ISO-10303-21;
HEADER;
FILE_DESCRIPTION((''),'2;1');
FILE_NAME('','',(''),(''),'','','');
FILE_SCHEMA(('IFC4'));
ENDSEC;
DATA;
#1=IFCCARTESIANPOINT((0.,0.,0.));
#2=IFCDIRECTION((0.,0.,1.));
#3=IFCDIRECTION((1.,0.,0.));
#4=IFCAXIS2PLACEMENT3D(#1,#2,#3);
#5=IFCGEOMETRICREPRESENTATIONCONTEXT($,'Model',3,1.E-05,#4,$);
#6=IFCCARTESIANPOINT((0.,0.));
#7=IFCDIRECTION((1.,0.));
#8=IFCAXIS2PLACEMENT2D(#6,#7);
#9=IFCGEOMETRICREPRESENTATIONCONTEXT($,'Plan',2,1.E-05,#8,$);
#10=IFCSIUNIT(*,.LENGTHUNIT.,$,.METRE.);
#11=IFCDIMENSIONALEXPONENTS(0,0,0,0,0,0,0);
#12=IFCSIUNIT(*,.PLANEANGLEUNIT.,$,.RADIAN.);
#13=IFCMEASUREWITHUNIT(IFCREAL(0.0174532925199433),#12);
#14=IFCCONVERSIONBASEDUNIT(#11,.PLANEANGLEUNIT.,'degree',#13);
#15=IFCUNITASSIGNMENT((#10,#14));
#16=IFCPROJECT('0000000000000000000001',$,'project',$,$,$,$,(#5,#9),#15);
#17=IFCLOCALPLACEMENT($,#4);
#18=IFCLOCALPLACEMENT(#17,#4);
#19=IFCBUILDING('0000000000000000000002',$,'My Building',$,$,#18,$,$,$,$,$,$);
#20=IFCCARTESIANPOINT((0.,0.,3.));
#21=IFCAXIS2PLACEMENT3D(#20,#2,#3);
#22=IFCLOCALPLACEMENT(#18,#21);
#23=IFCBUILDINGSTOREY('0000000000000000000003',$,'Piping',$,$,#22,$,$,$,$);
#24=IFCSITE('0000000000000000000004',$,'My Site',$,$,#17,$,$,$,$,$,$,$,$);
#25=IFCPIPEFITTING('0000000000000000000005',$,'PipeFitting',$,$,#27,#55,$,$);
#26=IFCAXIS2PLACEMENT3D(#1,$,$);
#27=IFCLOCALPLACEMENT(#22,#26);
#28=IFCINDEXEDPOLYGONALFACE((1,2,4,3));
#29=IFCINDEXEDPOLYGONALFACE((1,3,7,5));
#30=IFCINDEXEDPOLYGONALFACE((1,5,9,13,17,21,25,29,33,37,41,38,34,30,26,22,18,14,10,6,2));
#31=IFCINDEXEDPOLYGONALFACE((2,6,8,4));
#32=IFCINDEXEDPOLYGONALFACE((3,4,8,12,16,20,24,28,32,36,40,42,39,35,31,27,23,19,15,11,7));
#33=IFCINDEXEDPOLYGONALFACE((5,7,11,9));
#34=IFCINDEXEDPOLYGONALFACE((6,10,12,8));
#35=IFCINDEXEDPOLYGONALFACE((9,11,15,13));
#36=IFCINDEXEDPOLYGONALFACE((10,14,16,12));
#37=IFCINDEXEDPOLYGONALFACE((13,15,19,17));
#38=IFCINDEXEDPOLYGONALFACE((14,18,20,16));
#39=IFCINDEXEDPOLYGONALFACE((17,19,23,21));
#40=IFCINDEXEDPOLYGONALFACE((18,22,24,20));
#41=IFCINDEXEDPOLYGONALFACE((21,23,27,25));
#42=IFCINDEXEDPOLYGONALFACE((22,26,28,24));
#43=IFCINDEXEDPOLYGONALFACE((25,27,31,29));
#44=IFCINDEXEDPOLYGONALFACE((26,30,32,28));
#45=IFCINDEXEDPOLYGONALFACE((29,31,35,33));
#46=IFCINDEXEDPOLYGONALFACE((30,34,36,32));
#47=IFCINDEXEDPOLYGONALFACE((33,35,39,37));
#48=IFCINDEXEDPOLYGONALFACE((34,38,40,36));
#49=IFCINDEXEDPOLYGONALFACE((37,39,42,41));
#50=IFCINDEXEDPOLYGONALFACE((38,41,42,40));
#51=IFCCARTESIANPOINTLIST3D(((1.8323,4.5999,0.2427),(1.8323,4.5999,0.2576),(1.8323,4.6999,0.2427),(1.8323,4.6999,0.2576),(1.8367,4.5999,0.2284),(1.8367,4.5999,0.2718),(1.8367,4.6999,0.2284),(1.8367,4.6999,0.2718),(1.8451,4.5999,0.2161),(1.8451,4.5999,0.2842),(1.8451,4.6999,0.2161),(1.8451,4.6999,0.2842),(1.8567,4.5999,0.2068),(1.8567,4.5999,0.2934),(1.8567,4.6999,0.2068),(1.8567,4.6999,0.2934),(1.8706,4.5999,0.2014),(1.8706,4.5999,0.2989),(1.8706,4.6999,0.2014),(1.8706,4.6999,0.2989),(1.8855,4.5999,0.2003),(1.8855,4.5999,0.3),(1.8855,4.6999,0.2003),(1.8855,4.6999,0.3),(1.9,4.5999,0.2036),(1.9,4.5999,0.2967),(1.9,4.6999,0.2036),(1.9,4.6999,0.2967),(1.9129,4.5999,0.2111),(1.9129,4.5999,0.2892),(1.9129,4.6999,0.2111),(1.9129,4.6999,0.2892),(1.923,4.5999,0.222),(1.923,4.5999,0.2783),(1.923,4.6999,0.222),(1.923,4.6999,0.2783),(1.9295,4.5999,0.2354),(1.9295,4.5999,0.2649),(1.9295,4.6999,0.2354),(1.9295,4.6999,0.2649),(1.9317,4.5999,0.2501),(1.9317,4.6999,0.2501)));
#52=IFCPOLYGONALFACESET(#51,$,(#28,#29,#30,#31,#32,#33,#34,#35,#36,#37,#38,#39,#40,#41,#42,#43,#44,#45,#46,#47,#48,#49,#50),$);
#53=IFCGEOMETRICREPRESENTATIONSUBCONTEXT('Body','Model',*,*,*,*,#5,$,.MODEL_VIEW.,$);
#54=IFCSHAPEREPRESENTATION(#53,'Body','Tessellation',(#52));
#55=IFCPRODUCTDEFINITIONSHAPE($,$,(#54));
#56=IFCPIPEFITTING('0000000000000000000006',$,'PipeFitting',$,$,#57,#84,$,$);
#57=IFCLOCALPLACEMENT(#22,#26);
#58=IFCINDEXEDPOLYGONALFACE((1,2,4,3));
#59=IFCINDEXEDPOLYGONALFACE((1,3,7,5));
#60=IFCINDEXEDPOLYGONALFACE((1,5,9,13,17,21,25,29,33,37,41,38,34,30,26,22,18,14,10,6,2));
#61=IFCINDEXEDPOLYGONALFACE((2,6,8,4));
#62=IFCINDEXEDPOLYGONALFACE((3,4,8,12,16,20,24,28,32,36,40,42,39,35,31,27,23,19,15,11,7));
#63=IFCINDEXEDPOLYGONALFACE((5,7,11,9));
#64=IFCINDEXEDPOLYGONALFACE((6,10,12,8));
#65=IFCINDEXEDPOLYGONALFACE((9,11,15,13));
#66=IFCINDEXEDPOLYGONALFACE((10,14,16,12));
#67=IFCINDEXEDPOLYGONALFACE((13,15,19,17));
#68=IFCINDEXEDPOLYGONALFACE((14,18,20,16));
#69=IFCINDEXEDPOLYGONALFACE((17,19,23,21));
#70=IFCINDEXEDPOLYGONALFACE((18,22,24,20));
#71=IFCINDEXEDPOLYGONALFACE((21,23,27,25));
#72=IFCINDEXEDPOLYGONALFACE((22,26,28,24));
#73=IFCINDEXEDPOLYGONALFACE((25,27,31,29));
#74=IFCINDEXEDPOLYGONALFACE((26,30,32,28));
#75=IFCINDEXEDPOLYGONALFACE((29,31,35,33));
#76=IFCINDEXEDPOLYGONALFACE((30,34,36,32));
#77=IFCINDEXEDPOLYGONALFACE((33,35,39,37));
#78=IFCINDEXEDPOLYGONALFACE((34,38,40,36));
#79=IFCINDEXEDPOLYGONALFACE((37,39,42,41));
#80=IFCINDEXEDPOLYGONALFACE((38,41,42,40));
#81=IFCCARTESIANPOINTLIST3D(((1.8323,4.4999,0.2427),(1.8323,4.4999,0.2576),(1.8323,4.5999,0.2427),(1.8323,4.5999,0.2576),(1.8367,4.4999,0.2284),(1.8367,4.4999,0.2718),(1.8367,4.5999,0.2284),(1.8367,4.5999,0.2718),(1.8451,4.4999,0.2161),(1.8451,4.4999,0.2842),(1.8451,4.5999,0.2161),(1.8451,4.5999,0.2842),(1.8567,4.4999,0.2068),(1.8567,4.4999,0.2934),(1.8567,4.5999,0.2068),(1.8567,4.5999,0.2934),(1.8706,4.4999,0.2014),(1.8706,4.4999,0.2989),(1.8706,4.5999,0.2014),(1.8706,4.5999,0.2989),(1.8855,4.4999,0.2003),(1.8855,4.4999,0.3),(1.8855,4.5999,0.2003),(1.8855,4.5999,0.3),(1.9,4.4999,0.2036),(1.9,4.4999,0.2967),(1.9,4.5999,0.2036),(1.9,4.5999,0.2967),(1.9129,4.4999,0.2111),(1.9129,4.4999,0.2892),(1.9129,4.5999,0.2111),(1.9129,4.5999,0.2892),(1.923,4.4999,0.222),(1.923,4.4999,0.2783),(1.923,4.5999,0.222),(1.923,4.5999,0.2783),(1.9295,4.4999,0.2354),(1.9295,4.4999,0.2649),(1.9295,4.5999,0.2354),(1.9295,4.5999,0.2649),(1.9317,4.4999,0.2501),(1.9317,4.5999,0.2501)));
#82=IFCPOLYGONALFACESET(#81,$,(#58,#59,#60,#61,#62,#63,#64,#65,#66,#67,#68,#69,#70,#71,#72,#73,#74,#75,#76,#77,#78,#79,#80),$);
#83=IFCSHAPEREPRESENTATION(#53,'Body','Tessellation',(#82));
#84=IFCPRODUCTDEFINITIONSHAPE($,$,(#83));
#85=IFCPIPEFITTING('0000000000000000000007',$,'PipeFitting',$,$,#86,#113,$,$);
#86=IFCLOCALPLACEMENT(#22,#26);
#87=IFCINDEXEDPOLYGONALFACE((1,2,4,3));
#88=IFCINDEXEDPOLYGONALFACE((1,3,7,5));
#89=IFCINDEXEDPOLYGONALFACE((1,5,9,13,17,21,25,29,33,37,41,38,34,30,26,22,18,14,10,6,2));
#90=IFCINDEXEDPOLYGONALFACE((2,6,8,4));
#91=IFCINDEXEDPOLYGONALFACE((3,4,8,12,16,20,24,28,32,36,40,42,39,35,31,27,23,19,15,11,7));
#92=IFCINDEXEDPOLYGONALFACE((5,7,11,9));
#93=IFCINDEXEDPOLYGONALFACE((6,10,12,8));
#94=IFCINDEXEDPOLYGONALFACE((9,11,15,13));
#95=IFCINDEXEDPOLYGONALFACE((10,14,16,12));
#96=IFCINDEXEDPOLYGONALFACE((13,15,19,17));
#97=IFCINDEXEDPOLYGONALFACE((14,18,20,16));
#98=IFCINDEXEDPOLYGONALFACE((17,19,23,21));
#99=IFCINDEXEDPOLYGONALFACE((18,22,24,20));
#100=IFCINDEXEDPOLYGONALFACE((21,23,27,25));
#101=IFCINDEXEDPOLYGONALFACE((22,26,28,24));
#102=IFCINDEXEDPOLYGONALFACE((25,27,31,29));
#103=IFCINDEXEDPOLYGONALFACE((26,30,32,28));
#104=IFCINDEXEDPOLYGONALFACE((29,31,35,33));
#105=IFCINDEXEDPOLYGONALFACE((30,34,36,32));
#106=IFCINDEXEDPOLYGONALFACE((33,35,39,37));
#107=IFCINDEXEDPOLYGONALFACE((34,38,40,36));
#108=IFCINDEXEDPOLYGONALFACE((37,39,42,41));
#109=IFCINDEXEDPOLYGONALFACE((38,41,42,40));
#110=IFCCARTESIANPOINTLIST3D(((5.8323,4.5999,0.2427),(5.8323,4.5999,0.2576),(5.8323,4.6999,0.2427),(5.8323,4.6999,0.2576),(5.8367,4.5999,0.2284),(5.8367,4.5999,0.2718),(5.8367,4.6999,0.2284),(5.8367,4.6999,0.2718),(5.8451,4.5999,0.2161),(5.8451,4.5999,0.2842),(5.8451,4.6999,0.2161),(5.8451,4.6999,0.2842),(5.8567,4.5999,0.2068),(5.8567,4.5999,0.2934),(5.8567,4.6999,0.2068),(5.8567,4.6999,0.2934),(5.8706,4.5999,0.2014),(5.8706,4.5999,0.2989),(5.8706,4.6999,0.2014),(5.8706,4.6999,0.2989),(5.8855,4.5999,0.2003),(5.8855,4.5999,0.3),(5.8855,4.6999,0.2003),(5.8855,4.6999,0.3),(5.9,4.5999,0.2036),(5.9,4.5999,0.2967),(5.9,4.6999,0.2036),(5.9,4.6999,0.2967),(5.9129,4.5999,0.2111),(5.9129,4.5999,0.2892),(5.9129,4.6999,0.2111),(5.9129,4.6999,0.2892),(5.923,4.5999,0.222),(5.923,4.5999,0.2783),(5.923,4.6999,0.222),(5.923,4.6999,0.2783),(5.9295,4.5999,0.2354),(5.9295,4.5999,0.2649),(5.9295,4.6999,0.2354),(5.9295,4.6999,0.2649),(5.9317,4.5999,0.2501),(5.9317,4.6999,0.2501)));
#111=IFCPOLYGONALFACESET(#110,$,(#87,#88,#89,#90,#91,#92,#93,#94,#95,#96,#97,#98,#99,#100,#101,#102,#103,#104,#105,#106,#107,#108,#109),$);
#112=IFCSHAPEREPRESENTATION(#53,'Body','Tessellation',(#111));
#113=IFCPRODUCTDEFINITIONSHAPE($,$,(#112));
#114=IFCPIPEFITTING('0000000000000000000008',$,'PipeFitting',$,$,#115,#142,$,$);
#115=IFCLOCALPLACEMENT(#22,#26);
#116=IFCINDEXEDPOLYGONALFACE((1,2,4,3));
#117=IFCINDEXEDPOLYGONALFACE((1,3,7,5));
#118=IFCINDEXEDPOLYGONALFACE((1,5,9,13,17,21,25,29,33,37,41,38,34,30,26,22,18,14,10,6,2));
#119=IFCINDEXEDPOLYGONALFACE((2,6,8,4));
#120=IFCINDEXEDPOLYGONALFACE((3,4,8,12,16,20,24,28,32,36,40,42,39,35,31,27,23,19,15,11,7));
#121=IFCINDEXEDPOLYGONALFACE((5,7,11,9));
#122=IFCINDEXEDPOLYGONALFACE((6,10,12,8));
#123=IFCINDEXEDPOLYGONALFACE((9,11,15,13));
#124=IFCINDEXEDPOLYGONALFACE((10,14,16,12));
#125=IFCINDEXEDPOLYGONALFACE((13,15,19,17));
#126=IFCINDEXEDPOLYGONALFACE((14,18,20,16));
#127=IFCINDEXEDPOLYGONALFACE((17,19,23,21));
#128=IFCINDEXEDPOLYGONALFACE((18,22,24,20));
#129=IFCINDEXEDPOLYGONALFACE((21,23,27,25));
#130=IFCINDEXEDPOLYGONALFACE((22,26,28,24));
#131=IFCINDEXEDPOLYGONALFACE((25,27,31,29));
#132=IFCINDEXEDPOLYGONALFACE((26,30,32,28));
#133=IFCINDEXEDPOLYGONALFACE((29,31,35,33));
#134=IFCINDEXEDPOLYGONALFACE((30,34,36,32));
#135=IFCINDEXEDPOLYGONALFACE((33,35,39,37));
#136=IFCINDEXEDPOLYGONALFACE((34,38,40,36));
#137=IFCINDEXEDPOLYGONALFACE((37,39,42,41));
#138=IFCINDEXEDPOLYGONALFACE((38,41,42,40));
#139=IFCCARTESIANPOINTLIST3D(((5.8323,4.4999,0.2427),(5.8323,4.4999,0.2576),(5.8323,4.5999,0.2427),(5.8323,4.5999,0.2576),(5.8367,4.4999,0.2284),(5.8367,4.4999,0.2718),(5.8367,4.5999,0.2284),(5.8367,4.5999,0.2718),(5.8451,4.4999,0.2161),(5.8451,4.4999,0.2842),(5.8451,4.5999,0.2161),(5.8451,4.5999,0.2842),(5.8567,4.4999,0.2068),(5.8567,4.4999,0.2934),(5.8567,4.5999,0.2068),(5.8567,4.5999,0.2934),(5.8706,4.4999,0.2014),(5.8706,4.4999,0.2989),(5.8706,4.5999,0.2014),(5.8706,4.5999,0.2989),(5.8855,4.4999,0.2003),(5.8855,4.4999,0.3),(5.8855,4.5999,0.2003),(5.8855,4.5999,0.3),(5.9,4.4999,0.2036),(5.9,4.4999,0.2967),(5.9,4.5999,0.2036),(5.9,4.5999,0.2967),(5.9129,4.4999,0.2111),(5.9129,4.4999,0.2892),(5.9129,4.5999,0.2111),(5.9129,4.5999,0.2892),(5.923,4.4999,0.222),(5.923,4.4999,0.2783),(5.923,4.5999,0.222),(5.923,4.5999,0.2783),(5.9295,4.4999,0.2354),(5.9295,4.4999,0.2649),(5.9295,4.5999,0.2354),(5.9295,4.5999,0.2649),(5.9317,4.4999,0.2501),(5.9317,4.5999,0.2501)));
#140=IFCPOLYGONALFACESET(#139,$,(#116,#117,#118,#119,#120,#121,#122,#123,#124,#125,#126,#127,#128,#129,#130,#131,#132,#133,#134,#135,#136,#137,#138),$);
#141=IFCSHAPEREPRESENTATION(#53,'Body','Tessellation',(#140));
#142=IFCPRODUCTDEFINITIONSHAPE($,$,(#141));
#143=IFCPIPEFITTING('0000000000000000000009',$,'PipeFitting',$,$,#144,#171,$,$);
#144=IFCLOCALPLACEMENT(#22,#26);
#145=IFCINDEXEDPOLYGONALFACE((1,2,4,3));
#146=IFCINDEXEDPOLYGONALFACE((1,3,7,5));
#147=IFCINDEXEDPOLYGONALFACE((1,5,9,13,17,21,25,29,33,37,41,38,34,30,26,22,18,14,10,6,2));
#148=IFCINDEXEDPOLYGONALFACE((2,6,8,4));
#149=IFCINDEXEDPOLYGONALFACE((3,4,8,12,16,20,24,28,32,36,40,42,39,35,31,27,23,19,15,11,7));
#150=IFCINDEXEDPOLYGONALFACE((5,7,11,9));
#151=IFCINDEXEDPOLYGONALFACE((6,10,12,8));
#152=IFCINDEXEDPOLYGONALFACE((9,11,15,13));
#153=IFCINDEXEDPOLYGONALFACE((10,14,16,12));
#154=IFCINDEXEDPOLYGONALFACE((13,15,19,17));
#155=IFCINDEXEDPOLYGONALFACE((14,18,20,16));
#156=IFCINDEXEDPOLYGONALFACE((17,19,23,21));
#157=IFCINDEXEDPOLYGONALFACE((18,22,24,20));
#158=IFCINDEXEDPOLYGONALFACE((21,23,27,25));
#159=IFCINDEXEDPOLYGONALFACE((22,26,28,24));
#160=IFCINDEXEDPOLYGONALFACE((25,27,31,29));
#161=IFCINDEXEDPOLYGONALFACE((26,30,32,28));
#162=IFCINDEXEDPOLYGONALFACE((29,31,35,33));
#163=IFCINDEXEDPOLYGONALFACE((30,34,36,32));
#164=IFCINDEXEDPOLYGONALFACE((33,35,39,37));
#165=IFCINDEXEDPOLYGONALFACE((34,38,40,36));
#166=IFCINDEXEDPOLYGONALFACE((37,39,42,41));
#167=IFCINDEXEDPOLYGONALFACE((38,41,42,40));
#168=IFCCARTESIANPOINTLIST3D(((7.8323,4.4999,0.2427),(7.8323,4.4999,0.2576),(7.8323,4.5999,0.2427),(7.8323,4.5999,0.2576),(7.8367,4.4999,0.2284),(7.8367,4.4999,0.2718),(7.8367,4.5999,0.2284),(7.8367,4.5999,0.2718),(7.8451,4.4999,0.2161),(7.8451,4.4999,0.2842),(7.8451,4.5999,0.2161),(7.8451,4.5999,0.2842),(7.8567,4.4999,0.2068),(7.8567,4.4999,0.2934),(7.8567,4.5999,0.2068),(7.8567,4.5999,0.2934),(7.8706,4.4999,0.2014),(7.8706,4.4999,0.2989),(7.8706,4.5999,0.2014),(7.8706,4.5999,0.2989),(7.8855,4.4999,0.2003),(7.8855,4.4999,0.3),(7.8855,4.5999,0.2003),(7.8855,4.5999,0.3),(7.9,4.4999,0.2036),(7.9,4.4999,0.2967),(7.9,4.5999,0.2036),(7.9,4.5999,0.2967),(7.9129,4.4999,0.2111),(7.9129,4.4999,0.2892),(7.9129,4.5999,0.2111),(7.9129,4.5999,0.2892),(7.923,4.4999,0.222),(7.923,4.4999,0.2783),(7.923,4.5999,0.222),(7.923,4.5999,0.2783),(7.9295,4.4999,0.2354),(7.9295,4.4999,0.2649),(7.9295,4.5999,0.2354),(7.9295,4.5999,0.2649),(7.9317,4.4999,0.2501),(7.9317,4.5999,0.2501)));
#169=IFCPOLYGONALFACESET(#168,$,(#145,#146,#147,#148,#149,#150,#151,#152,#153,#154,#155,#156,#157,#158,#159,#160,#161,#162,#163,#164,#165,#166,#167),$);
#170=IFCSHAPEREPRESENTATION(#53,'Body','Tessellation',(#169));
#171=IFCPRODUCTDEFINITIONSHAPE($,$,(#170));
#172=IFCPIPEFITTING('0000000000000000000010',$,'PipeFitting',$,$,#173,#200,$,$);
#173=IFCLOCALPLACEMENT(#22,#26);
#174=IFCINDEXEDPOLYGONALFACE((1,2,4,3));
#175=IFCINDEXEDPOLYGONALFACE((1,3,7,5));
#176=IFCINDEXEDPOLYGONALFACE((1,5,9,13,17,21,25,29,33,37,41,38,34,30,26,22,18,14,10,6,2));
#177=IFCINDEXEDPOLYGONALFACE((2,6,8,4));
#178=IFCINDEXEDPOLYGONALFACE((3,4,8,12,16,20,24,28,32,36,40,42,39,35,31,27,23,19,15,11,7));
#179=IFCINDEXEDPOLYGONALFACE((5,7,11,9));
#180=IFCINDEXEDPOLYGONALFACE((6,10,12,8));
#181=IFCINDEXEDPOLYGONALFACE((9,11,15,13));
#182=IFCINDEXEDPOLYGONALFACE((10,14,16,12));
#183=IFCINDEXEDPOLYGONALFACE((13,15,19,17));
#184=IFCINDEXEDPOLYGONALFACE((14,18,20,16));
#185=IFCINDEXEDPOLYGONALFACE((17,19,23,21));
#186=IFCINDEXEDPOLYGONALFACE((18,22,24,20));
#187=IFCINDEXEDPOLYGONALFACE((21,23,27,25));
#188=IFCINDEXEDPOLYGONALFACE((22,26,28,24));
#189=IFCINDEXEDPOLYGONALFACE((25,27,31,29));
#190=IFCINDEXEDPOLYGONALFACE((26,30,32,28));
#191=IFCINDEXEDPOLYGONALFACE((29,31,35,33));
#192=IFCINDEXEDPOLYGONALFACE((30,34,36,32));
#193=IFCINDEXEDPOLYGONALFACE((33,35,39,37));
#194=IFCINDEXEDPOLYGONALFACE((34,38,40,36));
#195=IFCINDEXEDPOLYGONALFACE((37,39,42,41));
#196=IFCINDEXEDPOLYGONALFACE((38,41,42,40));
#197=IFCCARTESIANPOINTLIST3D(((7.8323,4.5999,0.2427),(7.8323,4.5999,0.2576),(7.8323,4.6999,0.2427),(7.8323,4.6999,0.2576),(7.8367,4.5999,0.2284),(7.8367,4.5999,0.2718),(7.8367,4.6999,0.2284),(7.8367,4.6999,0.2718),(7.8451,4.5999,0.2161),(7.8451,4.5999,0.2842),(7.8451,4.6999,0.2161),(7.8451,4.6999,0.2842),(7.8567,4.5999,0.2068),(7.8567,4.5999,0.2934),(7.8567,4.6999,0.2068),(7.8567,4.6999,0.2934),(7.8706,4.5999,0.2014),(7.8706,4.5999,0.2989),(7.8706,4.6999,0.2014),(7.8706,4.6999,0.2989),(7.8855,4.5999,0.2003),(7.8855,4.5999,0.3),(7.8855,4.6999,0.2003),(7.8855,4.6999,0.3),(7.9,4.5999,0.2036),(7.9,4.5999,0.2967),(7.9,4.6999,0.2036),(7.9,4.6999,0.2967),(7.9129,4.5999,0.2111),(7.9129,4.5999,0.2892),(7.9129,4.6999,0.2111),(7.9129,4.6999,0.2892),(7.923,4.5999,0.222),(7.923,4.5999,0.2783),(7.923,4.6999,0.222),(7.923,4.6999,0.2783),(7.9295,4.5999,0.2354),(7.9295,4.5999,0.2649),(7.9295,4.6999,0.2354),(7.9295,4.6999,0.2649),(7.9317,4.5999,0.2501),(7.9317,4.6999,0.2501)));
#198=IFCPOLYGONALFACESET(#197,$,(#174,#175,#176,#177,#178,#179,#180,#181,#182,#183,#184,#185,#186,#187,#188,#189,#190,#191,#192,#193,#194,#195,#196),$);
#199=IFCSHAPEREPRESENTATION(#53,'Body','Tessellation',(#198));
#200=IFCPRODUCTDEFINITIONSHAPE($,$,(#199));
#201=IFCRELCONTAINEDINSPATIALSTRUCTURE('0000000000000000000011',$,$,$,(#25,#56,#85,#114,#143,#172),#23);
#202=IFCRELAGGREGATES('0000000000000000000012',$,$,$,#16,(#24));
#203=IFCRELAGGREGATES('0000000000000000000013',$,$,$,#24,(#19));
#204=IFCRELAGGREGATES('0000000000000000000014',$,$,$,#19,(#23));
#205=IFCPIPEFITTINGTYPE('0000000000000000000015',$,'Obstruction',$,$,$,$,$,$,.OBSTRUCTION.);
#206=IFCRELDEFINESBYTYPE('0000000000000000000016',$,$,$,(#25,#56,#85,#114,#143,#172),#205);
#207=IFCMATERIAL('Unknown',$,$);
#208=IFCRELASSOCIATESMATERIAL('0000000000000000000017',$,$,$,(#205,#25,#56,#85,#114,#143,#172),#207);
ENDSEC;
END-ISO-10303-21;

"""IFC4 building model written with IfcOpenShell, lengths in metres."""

from ifc_helpers import new_model, entity, si_unit, converted_unit, frame, origin_with_axes, origin_2d_with_axis, place, context, subcontext, project, spatial, circle, extrude, material, material_profile, profile_set, profile_usage, type_object, element, save


model = new_model("IFC4")

# Units and contexts
model_context = context("Model", 3, precision=1e-05, world=origin_with_axes())
plan_context = context("Plan", 2, precision=1e-05, world=origin_2d_with_axis())
body_context = subcontext(model_context, "Body", "Model", "MODEL_VIEW")
ifc_project = project(units=[si_unit("LENGTHUNIT", "METRE"), converted_unit("PLANEANGLEUNIT", "degree", entity("IfcReal", 0.0174532925199433), si_unit("PLANEANGLEUNIT", "RADIAN"), dimensions=[0, 0, 0, 0, 0, 0, 0])], contexts=[model_context, plan_context])

# Site, building, storey
site_placement = place(None, origin_with_axes())
site = spatial("IfcSite", under=ifc_project, at=site_placement, Name="My Site")
building_placement = place(site_placement, origin_with_axes())
building = spatial("IfcBuilding", under=site, at=building_placement, Name="My Building")
storey_placement = place(building_placement, frame((0.0, 0.0, 3.0), z_axis=(0.0, 0.0, 1.0), x_axis=(1.0, 0.0, 0.0)))
storey = spatial("IfcBuildingStorey", under=building, at=storey_placement, Name="Piping")

# Shared definitions
ifc_material = material(Name="Unknown")

# Pipe fittings
ifc_material_profile_1 = material_profile(ifc_material, circle(Radius=0.05))
ifc_profile_set_1 = profile_set([ifc_material_profile_1])
ifc_profile_usage_1 = profile_usage(ifc_profile_set_1, cardinal=5)
pipe_fitting_type_1 = type_object("IfcPipeFittingType", Name="Obstruction", PredefinedType="OBSTRUCTION", material=ifc_profile_set_1)
pipe_fitting_1_placement = place(storey_placement, frame((1.8817, 4.5999, 0.2501), z_axis=(0.0, 1.0, -0.000008), x_axis=(1.0, 0.0, 0.0)))
element("IfcPipeFitting", 1, at=pipe_fitting_1_placement, inside=storey, type_object=pipe_fitting_type_1, material=ifc_profile_usage_1, Name="PipeFitting", context=body_context, shape_type="SweptSolid", body=[
    extrude(circle(Radius=0.05), origin_with_axes(), (0.0, 0.0, 1.0), 0.1),
])
ifc_profile_usage_2 = profile_usage(ifc_profile_set_1, cardinal=5)
pipe_fitting_2_placement = place(storey_placement, frame((1.8817, 4.5999, 0.2501), z_axis=(0.0, -1.0, 0.000008), x_axis=(1.0, 0.0, 0.0)))
element("IfcPipeFitting", 2, at=pipe_fitting_2_placement, inside=storey, type_object=pipe_fitting_type_1, material=ifc_profile_usage_2, Name="PipeFitting", context=body_context, shape_type="SweptSolid", body=[
    extrude(circle(Radius=0.05), origin_with_axes(), (0.0, 0.0, 1.0), 0.1),
])
ifc_profile_usage_3 = profile_usage(ifc_profile_set_1, cardinal=5)
pipe_fitting_3_placement = place(storey_placement, frame((5.8817, 4.5999, 0.2501), z_axis=(0.0, 1.0, -0.000008), x_axis=(1.0, 0.0, 0.0)))
element("IfcPipeFitting", 3, at=pipe_fitting_3_placement, inside=storey, type_object=pipe_fitting_type_1, material=ifc_profile_usage_3, Name="PipeFitting", context=body_context, shape_type="SweptSolid", body=[
    extrude(circle(Radius=0.05), origin_with_axes(), (0.0, 0.0, 1.0), 0.1),
])
ifc_profile_usage_4 = profile_usage(ifc_profile_set_1, cardinal=5)
pipe_fitting_4_placement = place(storey_placement, frame((5.8817, 4.5999, 0.2501), z_axis=(0.0, -1.0, 0.000008), x_axis=(1.0, 0.0, 0.0)))
element("IfcPipeFitting", 4, at=pipe_fitting_4_placement, inside=storey, type_object=pipe_fitting_type_1, material=ifc_profile_usage_4, Name="PipeFitting", context=body_context, shape_type="SweptSolid", body=[
    extrude(circle(Radius=0.05), origin_with_axes(), (0.0, 0.0, 1.0), 0.1),
])
ifc_profile_usage_5 = profile_usage(ifc_profile_set_1, cardinal=5)
pipe_fitting_5_placement = place(storey_placement, frame((7.8817, 4.5999, 0.2501), z_axis=(0.0, -1.0, 0.000008), x_axis=(1.0, 0.0, 0.0)))
element("IfcPipeFitting", 5, at=pipe_fitting_5_placement, inside=storey, type_object=pipe_fitting_type_1, material=ifc_profile_usage_5, Name="PipeFitting", context=body_context, shape_type="SweptSolid", body=[
    extrude(circle(Radius=0.05), origin_with_axes(), (0.0, 0.0, 1.0), 0.1),
])
ifc_profile_usage_6 = profile_usage(ifc_profile_set_1, cardinal=5)
pipe_fitting_6_placement = place(storey_placement, frame((7.8817, 4.5999, 0.2501), z_axis=(0.0, 1.0, -0.000008), x_axis=(1.0, 0.0, 0.0)))
element("IfcPipeFitting", 6, at=pipe_fitting_6_placement, inside=storey, type_object=pipe_fitting_type_1, material=ifc_profile_usage_6, Name="PipeFitting", context=body_context, shape_type="SweptSolid", body=[
    extrude(circle(Radius=0.05), origin_with_axes(), (0.0, 0.0, 1.0), 0.1),
])

save(model, "model.ifc")
